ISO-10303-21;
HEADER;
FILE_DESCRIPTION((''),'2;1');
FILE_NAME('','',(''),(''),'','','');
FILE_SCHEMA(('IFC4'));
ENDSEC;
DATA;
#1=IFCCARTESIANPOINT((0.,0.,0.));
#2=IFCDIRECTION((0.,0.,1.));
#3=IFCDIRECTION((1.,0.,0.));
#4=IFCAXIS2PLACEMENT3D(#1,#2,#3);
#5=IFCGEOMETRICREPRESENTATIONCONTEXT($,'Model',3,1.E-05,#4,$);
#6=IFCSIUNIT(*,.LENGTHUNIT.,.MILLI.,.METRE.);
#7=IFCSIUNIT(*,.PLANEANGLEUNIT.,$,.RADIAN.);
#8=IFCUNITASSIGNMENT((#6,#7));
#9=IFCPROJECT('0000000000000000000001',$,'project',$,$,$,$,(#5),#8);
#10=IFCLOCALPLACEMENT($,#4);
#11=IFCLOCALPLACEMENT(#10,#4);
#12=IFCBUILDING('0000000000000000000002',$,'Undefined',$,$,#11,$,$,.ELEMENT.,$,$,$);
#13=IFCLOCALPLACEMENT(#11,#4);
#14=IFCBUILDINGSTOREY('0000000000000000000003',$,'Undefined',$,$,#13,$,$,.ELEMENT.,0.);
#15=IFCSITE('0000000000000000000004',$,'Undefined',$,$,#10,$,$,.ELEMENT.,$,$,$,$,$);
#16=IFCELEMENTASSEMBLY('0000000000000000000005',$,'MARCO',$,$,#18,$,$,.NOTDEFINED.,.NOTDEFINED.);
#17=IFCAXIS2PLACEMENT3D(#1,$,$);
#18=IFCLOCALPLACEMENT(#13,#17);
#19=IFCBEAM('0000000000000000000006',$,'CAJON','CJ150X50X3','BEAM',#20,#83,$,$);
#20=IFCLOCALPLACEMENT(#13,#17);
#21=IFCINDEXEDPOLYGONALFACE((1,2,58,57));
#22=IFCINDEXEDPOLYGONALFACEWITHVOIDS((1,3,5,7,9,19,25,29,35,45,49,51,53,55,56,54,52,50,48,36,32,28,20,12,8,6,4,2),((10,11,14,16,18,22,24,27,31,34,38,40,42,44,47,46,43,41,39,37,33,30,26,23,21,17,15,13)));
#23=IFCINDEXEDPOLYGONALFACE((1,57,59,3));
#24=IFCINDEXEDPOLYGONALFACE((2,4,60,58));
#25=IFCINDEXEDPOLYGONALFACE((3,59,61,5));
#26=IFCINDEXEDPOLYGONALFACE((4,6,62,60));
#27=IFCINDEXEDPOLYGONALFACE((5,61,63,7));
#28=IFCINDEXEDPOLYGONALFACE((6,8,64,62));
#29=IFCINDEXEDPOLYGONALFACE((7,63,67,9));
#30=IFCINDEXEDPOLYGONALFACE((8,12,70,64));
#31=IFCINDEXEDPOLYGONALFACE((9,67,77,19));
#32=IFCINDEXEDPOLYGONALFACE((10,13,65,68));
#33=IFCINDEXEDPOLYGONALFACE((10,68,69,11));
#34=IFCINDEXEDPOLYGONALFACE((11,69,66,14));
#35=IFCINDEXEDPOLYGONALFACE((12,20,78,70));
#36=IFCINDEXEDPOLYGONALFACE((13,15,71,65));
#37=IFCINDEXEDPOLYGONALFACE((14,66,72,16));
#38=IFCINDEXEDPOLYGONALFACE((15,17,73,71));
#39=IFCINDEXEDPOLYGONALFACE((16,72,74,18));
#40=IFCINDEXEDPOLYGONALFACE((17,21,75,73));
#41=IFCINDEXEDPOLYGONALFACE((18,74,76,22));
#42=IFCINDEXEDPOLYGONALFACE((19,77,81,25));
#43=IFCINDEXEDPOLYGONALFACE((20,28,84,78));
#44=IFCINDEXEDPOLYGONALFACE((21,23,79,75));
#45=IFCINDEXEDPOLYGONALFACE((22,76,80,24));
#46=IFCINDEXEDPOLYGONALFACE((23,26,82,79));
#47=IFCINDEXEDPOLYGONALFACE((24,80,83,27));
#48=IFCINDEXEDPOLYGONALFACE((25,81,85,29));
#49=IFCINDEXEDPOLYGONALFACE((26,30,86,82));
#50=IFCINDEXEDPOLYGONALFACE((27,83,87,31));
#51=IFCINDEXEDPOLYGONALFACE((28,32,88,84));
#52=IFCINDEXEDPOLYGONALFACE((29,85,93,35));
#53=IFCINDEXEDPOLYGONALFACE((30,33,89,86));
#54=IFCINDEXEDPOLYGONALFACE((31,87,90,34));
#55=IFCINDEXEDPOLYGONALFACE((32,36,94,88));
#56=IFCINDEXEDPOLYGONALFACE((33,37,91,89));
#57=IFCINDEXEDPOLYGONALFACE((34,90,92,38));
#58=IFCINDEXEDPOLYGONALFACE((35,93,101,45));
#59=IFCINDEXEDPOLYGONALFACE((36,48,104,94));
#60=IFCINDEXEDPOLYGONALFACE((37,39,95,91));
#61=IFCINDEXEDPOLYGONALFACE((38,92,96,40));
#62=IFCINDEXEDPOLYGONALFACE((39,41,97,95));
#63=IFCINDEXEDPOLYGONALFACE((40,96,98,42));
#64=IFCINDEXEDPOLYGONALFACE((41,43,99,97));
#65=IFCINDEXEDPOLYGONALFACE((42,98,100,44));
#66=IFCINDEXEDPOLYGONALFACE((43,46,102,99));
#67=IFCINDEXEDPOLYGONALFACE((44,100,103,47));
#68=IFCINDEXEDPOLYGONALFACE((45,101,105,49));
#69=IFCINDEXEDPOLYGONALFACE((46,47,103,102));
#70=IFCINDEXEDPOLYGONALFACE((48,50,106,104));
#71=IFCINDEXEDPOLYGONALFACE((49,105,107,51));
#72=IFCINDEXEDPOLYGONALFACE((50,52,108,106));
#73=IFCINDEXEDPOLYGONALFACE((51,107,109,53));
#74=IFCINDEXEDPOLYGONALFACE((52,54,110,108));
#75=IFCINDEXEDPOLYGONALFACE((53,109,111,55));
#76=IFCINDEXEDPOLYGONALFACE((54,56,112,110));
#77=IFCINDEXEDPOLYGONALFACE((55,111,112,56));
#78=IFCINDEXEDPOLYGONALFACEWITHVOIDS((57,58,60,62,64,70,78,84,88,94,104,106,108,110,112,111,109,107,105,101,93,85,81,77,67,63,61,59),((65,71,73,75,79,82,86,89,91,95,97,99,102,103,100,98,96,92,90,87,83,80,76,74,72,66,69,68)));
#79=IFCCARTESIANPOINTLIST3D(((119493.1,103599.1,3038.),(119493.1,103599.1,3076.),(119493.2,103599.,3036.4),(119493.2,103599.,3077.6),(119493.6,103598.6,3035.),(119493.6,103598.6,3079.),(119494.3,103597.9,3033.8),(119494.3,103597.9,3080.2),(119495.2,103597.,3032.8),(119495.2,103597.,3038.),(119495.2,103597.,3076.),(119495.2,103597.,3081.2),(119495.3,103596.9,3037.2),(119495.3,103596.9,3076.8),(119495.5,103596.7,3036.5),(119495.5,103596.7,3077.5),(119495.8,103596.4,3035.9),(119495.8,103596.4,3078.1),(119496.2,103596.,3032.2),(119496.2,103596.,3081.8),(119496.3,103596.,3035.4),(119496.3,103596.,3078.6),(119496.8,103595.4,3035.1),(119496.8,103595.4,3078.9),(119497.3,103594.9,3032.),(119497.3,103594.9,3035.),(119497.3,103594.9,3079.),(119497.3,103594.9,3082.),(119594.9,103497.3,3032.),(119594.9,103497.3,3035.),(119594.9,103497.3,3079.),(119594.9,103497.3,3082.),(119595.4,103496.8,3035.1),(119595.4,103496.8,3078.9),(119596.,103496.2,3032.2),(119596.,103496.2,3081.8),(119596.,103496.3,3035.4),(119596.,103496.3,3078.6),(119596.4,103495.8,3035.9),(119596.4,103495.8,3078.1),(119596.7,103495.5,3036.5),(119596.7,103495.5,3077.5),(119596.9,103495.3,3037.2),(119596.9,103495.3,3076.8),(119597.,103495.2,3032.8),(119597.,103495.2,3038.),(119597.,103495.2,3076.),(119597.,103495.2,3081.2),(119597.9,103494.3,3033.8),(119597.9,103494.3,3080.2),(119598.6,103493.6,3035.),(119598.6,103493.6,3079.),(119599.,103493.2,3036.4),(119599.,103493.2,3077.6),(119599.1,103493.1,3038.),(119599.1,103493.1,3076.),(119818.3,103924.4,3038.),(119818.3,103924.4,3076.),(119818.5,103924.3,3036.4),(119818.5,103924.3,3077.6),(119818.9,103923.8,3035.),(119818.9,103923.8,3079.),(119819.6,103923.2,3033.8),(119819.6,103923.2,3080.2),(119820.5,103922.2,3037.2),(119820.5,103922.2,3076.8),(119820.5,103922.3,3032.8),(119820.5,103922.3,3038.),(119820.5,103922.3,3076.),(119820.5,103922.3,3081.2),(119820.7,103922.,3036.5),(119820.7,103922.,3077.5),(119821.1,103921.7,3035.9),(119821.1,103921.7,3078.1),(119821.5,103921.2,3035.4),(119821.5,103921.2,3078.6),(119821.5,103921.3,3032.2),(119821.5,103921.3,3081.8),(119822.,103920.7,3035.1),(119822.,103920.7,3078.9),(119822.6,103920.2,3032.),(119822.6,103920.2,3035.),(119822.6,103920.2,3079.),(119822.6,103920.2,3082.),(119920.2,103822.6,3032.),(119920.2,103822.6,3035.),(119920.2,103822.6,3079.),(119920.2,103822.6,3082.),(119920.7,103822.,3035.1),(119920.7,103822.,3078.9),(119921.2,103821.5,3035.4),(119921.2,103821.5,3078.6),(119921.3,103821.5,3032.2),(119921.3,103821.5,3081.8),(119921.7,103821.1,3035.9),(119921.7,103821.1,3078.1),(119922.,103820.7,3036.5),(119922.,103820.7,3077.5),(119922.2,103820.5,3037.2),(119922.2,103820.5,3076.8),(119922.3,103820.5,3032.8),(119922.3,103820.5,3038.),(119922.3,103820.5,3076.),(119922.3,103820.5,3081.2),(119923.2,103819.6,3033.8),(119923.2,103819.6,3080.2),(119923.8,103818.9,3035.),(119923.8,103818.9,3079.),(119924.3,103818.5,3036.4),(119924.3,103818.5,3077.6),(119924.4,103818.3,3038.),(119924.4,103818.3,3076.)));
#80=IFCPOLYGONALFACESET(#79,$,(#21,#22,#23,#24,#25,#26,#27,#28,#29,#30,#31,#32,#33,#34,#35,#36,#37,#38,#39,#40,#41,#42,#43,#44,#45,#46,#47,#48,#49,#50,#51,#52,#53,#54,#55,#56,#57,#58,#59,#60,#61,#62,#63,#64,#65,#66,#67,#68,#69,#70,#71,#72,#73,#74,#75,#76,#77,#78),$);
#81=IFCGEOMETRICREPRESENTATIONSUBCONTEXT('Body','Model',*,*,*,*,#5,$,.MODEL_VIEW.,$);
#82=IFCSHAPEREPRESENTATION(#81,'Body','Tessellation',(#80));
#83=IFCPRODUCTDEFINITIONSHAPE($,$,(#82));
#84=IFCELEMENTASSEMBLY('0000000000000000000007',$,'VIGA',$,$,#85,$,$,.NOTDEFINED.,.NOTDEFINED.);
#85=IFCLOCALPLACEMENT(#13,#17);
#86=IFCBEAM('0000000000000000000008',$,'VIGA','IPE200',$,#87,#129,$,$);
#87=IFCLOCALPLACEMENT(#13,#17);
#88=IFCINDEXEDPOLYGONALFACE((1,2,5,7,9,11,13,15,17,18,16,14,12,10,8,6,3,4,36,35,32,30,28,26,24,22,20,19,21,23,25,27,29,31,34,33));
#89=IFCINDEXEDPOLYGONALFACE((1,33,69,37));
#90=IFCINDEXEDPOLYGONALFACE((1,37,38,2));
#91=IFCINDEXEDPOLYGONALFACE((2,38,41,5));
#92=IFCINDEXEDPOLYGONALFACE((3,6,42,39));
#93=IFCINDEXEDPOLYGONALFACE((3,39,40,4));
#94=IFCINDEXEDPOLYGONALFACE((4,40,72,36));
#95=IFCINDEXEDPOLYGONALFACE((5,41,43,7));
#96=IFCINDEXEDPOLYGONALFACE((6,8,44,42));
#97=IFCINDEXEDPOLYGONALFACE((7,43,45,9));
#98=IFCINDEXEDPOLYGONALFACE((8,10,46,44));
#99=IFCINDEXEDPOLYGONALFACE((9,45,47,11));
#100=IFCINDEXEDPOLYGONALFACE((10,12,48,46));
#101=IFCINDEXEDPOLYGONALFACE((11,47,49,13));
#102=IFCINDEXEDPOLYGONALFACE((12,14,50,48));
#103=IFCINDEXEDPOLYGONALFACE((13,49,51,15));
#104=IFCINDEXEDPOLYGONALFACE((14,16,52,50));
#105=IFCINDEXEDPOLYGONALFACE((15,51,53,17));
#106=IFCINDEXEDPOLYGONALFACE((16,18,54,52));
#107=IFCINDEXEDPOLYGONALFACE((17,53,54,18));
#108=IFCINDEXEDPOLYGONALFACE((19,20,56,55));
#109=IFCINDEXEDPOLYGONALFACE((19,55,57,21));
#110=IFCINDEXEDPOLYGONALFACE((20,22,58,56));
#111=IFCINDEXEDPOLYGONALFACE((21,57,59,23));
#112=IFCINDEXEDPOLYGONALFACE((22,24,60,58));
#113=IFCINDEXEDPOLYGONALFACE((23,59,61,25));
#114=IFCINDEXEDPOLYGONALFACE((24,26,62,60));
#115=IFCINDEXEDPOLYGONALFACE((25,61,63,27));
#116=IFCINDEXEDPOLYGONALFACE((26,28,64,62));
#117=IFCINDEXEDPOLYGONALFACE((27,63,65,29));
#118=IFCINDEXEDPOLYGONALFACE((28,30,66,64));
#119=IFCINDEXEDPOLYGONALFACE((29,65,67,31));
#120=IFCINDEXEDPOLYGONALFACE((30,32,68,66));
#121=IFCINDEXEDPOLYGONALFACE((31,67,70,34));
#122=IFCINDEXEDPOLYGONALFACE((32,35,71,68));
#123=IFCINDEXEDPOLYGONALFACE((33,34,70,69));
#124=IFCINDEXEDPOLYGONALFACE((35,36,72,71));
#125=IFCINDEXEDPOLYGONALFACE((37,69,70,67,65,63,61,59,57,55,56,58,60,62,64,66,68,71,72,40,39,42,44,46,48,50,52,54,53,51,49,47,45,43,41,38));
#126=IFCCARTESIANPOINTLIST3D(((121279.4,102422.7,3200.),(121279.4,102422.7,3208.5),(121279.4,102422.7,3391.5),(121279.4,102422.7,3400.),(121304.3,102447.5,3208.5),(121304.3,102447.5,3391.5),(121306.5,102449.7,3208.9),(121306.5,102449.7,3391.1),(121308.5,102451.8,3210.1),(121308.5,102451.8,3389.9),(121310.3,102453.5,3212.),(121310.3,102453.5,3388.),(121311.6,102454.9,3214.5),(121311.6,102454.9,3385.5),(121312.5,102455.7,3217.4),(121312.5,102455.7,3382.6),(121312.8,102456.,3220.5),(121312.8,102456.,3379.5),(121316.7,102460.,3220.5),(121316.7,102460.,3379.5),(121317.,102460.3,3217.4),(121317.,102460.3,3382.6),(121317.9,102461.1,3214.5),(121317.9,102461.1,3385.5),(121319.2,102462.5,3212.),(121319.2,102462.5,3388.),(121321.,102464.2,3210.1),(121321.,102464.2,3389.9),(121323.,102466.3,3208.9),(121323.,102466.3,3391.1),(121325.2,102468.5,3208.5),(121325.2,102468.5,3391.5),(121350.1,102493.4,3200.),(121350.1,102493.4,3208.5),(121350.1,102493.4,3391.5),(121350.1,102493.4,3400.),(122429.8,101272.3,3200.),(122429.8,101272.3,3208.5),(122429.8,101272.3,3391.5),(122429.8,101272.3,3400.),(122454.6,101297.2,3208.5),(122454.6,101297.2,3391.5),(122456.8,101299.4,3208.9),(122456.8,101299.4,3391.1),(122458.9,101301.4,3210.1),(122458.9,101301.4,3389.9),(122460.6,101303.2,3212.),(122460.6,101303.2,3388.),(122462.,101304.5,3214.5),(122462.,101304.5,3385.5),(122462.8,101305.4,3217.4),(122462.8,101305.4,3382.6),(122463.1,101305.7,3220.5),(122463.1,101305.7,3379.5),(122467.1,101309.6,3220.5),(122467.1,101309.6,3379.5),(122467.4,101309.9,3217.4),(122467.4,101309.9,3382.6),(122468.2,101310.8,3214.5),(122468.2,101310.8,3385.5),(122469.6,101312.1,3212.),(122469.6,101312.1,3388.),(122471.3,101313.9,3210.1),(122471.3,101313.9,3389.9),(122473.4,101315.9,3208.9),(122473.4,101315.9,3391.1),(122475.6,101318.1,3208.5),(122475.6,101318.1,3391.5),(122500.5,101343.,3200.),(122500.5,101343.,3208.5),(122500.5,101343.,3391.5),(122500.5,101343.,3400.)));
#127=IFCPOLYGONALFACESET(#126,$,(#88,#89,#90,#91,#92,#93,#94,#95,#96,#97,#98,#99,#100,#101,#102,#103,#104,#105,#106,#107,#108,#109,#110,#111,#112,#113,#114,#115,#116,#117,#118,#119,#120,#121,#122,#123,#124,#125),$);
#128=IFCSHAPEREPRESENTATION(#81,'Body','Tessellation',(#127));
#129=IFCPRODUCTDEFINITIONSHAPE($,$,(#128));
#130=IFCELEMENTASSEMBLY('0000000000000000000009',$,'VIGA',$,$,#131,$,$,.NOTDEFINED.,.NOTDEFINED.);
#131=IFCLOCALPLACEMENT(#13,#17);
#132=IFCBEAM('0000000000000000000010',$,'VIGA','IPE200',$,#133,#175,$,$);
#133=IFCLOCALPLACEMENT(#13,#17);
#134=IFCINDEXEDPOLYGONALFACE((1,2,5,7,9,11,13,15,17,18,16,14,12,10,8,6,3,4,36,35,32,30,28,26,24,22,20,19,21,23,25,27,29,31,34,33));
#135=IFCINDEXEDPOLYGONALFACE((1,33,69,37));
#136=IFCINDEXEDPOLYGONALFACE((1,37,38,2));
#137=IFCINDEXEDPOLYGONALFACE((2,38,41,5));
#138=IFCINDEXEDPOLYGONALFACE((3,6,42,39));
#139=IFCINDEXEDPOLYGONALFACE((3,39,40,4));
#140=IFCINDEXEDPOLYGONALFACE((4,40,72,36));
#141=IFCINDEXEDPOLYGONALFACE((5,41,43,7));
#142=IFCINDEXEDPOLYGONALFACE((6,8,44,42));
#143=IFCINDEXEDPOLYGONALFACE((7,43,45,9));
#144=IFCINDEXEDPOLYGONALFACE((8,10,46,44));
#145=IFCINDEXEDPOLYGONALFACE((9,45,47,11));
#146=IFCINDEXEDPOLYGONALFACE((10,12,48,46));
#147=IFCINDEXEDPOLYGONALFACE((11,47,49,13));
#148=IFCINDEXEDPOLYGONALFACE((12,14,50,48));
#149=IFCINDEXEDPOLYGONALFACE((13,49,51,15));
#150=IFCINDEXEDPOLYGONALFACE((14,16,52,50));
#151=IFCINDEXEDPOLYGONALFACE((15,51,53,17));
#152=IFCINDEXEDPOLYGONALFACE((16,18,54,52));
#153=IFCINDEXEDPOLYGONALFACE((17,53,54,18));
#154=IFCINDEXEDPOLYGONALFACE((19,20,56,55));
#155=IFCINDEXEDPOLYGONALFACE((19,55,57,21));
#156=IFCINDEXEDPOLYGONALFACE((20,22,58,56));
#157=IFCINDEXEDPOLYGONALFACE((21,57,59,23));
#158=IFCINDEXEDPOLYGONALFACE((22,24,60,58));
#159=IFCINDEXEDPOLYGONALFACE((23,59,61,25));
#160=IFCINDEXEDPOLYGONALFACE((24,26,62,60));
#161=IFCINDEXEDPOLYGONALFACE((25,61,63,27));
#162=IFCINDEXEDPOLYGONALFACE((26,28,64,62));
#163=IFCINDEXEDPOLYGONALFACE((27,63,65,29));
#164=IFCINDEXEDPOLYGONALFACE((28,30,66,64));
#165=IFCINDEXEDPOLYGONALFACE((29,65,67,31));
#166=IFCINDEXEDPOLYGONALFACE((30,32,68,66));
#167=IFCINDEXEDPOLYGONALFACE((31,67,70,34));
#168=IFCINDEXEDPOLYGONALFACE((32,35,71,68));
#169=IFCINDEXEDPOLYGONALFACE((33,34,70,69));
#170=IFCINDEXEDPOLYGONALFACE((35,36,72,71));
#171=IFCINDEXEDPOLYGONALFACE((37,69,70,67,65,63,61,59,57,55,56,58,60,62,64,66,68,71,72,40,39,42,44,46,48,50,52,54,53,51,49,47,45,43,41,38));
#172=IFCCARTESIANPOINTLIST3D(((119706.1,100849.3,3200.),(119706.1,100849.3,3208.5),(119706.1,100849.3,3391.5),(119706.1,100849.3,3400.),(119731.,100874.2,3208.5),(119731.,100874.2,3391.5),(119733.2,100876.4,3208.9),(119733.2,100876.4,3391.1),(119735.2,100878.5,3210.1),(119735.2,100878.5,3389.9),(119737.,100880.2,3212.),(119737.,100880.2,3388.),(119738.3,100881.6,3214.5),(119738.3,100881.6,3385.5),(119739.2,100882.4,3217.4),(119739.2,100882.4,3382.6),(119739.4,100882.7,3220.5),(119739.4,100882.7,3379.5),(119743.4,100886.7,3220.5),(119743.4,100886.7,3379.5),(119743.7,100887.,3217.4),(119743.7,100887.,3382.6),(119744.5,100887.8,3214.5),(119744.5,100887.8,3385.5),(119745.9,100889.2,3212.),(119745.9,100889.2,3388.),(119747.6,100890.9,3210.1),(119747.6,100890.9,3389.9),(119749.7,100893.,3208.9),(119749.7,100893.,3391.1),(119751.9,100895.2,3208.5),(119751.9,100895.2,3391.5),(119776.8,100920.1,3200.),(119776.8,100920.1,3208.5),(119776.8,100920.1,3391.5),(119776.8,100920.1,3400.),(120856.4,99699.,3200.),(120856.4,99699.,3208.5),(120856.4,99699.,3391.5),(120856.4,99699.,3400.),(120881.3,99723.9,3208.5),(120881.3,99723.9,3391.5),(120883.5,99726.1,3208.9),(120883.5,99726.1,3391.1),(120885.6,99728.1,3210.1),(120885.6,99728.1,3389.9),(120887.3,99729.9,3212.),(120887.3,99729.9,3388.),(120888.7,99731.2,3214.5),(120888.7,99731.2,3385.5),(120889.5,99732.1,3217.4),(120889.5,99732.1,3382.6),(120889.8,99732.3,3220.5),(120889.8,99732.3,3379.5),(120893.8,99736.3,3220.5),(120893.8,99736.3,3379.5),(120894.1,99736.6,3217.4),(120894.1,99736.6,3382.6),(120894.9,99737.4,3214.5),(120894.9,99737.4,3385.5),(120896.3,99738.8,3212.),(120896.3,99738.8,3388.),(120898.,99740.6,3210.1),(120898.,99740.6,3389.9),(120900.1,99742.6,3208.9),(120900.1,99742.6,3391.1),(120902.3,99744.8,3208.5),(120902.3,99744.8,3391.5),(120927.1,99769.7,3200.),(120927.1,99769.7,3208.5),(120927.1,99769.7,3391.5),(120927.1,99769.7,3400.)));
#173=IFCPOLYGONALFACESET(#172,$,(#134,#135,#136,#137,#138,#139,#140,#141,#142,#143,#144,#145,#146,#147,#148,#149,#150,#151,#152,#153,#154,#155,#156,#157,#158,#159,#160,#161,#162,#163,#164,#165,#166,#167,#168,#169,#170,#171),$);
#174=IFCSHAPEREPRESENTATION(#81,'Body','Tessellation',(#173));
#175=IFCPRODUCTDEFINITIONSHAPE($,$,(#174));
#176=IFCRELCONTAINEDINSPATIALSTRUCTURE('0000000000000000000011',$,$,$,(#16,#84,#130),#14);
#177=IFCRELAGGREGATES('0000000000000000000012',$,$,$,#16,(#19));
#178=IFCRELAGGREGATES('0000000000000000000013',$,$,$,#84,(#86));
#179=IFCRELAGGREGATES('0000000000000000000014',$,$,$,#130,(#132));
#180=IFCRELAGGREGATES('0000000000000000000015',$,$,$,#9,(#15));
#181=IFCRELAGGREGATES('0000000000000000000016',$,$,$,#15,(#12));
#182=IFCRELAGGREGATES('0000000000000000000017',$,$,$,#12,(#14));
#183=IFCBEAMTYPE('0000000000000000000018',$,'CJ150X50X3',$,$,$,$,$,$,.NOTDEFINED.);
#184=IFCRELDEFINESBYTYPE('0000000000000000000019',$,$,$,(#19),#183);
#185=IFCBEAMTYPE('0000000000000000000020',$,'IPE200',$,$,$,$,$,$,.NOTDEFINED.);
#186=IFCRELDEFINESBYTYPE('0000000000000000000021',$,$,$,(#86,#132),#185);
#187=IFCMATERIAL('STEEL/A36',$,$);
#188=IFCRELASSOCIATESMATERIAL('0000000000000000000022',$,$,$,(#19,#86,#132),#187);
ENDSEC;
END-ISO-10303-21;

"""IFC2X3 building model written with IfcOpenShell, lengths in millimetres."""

from ifc_helpers import new_model, si_unit, frame, origin_with_axes, origin_2d_with_axis, place, context, subcontext, project, spatial, hollow_rectangle, i_section, extrude, material, type_object, element, aggregate, save


model = new_model("IFC2X3")

# Units and contexts
model_context = context("Model", 3, precision=1e-05, world=origin_with_axes())
body_context = subcontext(model_context, "Body", "Model", "MODEL_VIEW")
ifc_project = project(units=[si_unit("LENGTHUNIT", "METRE", prefix="MILLI"), si_unit("PLANEANGLEUNIT", "RADIAN")], contexts=[model_context])

# Site, building, storey
site_placement = place(None, origin_with_axes())
site = spatial("IfcSite", under=ifc_project, at=site_placement, Name="Undefined", CompositionType="ELEMENT")
building_placement = place(site_placement, origin_with_axes())
building = spatial("IfcBuilding", under=site, at=building_placement, Name="Undefined", CompositionType="ELEMENT")
storey_placement = place(building_placement, origin_with_axes())
storey = spatial("IfcBuildingStorey", under=building, at=storey_placement, Name="Undefined", CompositionType="ELEMENT", Elevation=0.0)

# Element assembly, beam
ifc_material_1 = material(Name="STEEL/A36")
assembly_1_placement = place(storey_placement, origin_with_axes())
assembly_1 = element("IfcElementAssembly", 1, at=assembly_1_placement, inside=storey, Name="MARCO", AssemblyPlace="NOTDEFINED", PredefinedType="NOTDEFINED")
beam_type_1 = type_object("IfcBeamType", Name="CJ150X50X3", PredefinedType="NOTDEFINED")
beam_1_placement = place(assembly_1_placement, frame((119546.1, 103546.1, 3057.0), z_axis=(0.707107, -0.707107, 0.0), x_axis=(0.707107, 0.707107, 0.0)))
beam_1 = element("IfcBeam", 2, at=beam_1_placement, type_object=beam_type_1, material=ifc_material_1, Name="CAJON", Description="CJ150X50X3", ObjectType="BEAM", context=body_context, shape_type="SweptSolid", body=[
    extrude(hollow_rectangle(XDim=50.0, YDim=150.0, WallThickness=3.0, InnerFilletRadius=3.0, OuterFilletRadius=6.0, at=origin_2d_with_axis()), frame((460.0, 0.0, 0.0), z_axis=(-1.0, 0.0, 0.0), x_axis=(0.0, -1.0, 0.0)), (0.0, 0.0, 1.0), 460.0),
])

# Element assemblies, beams
assembly_2_placement = place(storey_placement, origin_with_axes())
assembly_2 = element("IfcElementAssembly", 3, at=assembly_2_placement, inside=storey, Name="VIGA", AssemblyPlace="NOTDEFINED", PredefinedType="NOTDEFINED")
beam_type_2 = type_object("IfcBeamType", Name="IPE200", PredefinedType="NOTDEFINED")
beam_2_placement = place(assembly_2_placement, frame((121314.7, 102458.0, 3300.0), z_axis=(0.0, 0.0, 1.0), x_axis=(0.707107, -0.707107, 0.0)))
beam_2 = element("IfcBeam", 4, at=beam_2_placement, type_object=beam_type_2, material=ifc_material_1, Name="VIGA", Description="IPE200", context=body_context, shape_type="SweptSolid", body=[
    extrude(i_section(OverallWidth=100.0, OverallDepth=200.0, WebThickness=5.6, FlangeThickness=8.5, FilletRadius=12.0, at=origin_2d_with_axis()), frame((1626.9, 0.0, 0.0), z_axis=(-1.0, 0.0, 0.0), x_axis=(0.0, -1.0, 0.0)), (0.0, 0.0, 1.0), 1626.9),
])
assembly_3_placement = place(storey_placement, origin_with_axes())
assembly_3 = element("IfcElementAssembly", 5, at=assembly_3_placement, inside=storey, Name="VIGA", AssemblyPlace="NOTDEFINED", PredefinedType="NOTDEFINED")
beam_3_placement = place(assembly_3_placement, frame((119741.4, 100884.7, 3300.0), z_axis=(0.0, 0.0, 1.0), x_axis=(0.707107, -0.707107, 0.0)))
beam_3 = element("IfcBeam", 6, at=beam_3_placement, type_object=beam_type_2, material=ifc_material_1, Name="VIGA", Description="IPE200", context=body_context, shape_type="SweptSolid", body=[
    extrude(i_section(OverallWidth=100.0, OverallDepth=200.0, WebThickness=5.6, FlangeThickness=8.5, FilletRadius=12.0, at=origin_2d_with_axis()), frame((1626.9, 0.0, 0.0), z_axis=(-1.0, 0.0, 0.0), x_axis=(0.0, -1.0, 0.0)), (0.0, 0.0, 1.0), 1626.9),
])

aggregate(assembly_1, [beam_1])

aggregate(assembly_2, [beam_2])
aggregate(assembly_3, [beam_3])

save(model, "model.ifc")
